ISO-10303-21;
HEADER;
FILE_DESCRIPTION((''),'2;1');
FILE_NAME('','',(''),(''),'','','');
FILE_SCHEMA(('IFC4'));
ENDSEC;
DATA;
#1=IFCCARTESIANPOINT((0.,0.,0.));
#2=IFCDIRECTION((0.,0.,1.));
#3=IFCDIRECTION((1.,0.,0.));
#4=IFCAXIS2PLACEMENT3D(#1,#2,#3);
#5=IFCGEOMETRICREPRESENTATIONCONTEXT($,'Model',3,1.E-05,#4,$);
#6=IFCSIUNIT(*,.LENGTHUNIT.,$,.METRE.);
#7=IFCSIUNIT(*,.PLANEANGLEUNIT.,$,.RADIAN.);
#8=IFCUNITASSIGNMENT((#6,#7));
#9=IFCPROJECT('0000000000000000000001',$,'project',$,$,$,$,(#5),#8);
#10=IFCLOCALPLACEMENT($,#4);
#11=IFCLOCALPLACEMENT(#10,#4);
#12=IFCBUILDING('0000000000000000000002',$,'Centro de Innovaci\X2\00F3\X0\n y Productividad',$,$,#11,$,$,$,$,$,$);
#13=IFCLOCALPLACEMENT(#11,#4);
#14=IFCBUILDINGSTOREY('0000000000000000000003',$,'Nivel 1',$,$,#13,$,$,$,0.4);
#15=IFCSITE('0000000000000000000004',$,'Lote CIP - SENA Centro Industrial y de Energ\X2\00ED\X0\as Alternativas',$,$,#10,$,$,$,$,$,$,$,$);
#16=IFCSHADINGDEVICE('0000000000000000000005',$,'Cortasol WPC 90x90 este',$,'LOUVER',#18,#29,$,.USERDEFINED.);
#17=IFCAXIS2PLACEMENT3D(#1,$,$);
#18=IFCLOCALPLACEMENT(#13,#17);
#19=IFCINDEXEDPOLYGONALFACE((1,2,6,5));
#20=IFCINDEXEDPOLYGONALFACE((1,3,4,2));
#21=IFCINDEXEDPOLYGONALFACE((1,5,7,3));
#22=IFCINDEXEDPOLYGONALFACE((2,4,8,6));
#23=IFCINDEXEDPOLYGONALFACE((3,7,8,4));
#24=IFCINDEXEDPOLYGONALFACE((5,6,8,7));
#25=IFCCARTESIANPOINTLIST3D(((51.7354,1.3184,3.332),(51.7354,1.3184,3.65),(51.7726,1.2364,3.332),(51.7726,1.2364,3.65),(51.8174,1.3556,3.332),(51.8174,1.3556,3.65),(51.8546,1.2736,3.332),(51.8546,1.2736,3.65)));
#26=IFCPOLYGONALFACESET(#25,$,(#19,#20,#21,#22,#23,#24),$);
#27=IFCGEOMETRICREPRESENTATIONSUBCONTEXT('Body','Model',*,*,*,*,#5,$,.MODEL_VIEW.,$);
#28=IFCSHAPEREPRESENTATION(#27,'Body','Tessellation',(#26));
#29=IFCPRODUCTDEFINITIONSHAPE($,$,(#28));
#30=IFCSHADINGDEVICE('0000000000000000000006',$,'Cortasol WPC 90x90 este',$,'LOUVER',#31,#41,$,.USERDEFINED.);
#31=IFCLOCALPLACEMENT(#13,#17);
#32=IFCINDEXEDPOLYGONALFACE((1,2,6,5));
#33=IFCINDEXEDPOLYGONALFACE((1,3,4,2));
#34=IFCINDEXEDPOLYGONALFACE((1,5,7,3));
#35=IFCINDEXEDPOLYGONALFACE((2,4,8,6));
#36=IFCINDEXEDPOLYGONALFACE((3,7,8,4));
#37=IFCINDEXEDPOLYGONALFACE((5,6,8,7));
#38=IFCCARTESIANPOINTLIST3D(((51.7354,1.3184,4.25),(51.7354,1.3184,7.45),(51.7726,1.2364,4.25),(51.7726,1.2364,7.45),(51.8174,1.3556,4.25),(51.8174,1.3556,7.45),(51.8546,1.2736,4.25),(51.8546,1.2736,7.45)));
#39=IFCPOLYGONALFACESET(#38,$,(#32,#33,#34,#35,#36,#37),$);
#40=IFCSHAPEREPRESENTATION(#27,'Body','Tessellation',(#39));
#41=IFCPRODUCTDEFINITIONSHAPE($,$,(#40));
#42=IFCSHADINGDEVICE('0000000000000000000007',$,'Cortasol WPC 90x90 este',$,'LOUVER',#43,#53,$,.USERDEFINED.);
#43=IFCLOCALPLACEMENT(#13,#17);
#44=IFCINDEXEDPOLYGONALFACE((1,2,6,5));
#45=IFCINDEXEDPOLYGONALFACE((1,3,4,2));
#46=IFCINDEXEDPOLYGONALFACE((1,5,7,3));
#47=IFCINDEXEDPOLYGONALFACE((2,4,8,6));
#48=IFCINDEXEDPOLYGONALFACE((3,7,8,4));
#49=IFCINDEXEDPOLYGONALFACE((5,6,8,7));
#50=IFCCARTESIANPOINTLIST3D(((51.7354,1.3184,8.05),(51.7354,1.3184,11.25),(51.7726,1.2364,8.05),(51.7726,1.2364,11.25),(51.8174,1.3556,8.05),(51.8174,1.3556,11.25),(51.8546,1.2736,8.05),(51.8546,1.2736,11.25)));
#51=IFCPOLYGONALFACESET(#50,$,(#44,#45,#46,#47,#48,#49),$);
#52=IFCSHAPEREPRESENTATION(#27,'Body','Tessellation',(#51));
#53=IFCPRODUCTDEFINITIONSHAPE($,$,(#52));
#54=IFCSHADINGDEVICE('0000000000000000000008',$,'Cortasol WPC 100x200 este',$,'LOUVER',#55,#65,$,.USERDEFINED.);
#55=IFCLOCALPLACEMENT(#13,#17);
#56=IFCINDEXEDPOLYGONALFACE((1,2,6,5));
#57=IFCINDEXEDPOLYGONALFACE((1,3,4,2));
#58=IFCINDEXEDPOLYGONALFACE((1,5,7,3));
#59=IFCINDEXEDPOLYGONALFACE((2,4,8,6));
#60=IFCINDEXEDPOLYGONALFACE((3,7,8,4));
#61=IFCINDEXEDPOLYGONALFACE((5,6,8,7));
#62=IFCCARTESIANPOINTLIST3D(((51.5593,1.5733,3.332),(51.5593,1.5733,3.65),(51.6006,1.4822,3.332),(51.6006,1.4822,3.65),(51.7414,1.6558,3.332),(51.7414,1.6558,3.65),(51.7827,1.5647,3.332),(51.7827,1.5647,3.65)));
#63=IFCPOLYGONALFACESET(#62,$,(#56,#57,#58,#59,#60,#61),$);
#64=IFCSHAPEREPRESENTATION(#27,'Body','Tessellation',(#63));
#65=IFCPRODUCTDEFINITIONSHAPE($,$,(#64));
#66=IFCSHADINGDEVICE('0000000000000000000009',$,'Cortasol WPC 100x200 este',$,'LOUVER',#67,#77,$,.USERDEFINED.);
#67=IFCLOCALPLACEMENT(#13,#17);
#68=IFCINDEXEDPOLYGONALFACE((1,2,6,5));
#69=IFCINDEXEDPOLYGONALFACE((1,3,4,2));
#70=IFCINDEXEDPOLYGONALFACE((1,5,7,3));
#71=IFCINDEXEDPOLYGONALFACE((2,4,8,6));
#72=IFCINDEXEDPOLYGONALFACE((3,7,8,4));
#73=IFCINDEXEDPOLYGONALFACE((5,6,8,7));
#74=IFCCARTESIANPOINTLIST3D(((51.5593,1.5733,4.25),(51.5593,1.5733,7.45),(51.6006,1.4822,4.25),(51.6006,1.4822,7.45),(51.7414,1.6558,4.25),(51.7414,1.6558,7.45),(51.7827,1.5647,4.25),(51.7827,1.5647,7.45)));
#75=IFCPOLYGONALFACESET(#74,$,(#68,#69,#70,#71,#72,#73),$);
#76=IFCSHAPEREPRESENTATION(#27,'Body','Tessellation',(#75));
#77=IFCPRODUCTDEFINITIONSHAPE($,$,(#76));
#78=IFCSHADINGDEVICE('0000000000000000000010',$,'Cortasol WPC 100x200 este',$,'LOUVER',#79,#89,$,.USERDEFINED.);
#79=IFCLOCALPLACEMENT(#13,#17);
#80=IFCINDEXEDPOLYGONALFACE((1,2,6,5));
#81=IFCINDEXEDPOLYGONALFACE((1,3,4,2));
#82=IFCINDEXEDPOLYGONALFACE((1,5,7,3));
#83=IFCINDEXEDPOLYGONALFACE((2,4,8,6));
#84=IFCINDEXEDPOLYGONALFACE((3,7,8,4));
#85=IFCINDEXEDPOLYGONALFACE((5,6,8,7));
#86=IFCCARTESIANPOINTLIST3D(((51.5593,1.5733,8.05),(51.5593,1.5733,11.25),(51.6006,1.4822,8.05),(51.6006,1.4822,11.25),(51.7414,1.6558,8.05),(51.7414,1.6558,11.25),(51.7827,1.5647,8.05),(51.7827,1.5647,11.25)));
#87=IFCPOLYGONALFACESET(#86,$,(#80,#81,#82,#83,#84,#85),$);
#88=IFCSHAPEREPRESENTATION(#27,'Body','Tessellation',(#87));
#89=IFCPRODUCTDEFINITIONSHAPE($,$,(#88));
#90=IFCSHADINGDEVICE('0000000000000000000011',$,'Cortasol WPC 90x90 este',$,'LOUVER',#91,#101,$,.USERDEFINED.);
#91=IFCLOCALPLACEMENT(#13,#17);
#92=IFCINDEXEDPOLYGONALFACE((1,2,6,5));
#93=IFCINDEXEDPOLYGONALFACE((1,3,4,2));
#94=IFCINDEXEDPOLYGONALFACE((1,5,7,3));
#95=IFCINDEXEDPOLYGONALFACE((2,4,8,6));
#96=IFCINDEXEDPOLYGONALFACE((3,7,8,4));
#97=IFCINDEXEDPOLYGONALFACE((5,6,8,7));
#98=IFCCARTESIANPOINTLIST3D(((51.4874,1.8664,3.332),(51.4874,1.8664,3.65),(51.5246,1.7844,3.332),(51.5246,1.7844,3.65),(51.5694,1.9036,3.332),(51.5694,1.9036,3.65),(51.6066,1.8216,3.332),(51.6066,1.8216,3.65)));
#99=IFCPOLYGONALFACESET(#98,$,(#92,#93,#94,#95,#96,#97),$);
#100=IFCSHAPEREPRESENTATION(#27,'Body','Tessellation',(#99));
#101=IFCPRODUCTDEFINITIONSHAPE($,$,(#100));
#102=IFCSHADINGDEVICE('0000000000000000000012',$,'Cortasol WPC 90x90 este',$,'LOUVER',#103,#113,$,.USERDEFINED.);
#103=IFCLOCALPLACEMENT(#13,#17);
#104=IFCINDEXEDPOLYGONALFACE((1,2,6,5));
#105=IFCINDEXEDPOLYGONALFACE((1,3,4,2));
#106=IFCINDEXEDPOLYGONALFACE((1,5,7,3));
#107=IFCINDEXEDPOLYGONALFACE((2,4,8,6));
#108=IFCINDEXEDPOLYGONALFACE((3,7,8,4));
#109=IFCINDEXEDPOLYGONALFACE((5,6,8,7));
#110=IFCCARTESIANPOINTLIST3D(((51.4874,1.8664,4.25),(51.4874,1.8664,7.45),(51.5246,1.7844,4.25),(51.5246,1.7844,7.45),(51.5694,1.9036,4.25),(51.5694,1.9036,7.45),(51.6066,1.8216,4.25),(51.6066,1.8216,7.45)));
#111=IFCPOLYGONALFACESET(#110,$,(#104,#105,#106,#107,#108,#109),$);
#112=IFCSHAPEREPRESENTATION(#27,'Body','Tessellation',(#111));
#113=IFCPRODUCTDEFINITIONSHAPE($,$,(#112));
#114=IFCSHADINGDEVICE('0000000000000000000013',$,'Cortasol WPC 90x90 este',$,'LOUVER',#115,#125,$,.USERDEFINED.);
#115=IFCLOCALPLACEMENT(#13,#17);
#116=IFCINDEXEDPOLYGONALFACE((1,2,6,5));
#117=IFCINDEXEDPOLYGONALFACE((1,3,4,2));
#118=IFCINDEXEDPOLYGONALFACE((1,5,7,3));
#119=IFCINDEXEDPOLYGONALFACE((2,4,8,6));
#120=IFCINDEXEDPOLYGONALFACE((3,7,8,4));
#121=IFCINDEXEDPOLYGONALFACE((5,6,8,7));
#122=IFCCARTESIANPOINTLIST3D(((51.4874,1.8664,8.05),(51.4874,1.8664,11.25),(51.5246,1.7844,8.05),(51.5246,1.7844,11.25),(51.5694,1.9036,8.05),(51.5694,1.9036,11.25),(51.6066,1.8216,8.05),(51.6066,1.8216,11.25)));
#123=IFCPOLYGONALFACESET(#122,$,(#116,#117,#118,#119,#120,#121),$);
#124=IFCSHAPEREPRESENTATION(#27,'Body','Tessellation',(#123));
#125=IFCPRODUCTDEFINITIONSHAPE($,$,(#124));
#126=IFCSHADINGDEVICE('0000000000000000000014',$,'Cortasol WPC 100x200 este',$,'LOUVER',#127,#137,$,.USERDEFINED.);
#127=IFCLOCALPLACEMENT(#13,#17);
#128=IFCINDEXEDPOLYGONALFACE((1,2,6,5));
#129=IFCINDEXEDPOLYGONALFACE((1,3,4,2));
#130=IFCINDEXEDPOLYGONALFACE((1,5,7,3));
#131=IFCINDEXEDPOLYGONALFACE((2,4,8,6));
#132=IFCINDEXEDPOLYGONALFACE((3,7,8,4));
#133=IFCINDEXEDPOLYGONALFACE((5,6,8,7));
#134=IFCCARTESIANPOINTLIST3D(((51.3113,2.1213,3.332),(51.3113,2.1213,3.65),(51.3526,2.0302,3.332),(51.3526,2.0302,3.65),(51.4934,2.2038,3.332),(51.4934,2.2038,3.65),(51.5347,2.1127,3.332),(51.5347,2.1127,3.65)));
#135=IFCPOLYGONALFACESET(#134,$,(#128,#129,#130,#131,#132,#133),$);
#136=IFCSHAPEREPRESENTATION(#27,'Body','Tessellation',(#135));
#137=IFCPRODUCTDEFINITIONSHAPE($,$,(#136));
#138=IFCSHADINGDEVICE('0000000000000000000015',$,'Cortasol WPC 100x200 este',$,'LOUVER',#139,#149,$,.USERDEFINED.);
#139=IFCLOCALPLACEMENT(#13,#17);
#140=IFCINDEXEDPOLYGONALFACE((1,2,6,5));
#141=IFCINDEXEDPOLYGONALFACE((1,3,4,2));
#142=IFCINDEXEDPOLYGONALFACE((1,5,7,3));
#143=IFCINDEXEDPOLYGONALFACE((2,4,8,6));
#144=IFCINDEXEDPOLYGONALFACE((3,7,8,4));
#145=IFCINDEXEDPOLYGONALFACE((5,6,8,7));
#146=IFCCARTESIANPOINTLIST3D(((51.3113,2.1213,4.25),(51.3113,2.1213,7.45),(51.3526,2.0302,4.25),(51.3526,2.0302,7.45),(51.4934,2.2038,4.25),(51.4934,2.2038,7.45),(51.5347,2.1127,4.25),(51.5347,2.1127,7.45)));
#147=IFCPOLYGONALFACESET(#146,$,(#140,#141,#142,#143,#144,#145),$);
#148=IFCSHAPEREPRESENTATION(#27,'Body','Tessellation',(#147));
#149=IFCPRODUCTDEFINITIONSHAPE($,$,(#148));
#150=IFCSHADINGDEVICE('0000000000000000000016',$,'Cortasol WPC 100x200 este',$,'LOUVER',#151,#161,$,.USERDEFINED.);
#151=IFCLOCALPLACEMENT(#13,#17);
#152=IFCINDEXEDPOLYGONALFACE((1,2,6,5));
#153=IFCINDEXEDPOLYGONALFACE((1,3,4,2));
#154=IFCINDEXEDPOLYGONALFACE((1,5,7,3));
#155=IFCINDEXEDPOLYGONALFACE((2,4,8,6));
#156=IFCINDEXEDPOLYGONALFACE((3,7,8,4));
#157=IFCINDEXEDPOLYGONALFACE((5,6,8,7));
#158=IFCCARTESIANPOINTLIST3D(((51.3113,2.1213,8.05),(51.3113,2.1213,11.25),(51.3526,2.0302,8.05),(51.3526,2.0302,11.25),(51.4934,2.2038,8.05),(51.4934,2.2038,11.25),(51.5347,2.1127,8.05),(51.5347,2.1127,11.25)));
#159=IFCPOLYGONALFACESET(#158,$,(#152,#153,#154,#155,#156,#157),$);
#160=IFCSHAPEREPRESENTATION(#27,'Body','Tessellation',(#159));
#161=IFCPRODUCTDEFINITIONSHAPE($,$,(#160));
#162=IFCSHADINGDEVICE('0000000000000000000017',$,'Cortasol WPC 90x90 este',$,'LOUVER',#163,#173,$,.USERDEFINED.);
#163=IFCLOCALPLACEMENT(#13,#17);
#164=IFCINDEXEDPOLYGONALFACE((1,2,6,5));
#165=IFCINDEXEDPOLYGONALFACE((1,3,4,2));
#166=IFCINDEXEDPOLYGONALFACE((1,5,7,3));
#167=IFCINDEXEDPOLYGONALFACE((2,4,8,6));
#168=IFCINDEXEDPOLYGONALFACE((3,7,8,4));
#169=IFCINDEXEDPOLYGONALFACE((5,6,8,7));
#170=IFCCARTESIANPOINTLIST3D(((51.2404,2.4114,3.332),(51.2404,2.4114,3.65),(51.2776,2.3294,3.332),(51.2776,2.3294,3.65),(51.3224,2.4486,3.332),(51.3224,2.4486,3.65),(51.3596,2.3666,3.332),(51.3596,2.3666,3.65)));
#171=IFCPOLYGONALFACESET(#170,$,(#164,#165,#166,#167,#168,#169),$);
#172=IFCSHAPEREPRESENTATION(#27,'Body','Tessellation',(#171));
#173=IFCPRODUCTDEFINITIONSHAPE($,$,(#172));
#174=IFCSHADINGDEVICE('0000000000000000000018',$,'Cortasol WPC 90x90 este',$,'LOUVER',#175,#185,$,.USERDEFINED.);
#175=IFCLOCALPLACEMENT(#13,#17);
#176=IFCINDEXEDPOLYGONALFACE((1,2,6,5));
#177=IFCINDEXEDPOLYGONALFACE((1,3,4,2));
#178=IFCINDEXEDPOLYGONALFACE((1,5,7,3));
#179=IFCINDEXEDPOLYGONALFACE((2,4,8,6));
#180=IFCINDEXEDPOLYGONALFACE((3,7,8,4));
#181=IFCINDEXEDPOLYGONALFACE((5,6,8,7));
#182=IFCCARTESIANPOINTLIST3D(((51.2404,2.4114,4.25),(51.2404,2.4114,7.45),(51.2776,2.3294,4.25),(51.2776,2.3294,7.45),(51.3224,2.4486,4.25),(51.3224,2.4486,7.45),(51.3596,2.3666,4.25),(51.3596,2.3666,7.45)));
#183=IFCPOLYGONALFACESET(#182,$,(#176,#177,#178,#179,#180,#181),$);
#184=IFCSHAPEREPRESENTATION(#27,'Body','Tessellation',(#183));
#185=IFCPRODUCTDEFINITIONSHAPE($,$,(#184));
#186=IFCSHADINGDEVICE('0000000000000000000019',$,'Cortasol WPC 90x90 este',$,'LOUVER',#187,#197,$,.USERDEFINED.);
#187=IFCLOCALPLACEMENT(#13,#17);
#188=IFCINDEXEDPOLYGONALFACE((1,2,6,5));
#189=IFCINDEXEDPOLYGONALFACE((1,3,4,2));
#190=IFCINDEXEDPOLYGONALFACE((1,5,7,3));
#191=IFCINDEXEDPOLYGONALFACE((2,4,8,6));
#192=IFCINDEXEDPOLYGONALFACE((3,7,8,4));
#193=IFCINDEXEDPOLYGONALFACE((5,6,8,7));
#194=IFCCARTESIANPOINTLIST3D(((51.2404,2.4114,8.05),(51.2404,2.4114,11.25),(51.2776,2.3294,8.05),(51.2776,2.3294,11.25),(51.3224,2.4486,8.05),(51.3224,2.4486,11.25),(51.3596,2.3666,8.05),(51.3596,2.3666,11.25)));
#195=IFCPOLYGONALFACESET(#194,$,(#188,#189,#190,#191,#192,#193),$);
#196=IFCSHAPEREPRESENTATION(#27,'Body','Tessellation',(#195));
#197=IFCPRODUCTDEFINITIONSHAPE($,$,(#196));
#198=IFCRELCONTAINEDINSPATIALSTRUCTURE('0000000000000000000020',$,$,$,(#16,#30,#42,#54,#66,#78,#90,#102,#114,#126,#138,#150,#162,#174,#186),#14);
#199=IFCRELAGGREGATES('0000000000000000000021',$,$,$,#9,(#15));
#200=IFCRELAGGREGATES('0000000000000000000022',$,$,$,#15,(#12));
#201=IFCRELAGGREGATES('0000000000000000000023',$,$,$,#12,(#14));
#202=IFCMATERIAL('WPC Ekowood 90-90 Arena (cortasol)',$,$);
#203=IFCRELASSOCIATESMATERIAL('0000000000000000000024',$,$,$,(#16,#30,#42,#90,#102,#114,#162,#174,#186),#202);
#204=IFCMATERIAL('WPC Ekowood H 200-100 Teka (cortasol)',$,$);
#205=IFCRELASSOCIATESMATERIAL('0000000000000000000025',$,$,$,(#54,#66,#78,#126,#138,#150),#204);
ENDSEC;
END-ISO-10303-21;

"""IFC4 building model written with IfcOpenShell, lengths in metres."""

from ifc_helpers import new_model, si_unit, frame, origin_with_axes, place, context, subcontext, project, spatial, polyline, outline, extrude, material, element, save


model = new_model("IFC4")

# Units and contexts
model_context = context("Model", 3, precision=1e-05, world=origin_with_axes())
body_context = subcontext(model_context, "Body", "Model", "MODEL_VIEW")
ifc_project = project(units=[si_unit("LENGTHUNIT", "METRE"), si_unit("PLANEANGLEUNIT", "RADIAN")], contexts=[model_context])

# Site, building, storey
site_placement = place(None, origin_with_axes())
site = spatial("IfcSite", under=ifc_project, at=site_placement, Name="Lote CIP - SENA Centro Industrial y de Energías Alternativas")
building_placement = place(site_placement, origin_with_axes())
building = spatial("IfcBuilding", under=site, at=building_placement, Name="Centro de Innovación y Productividad")
storey_placement = place(building_placement, origin_with_axes())
storey = spatial("IfcBuildingStorey", under=building, at=storey_placement, Name="Nivel 1", Elevation=0.4)

# Shading devices
ifc_material_1 = material(Name="WPC Ekowood 90-90 Arena (cortasol)")
shading_device_1_placement = place(storey_placement, origin_with_axes())
element("IfcShadingDevice", 1, at=shading_device_1_placement, inside=storey, material=ifc_material_1, Name="Cortasol WPC 90x90 este", ObjectType="LOUVER", PredefinedType="USERDEFINED", context=body_context, shape_type="SweptSolid", body=[
    extrude(outline(polyline([(51.7354, 1.3184), (51.8174, 1.3556), (51.8546, 1.2736), (51.7726, 1.2364), (51.7354, 1.3184)])), frame((0.0, 0.0, 3.332)), (0.0, 0.0, 1.0), 0.318),
])
shading_device_2_placement = place(storey_placement, origin_with_axes())
element("IfcShadingDevice", 2, at=shading_device_2_placement, inside=storey, material=ifc_material_1, Name="Cortasol WPC 90x90 este", ObjectType="LOUVER", PredefinedType="USERDEFINED", context=body_context, shape_type="SweptSolid", body=[
    extrude(outline(polyline([(51.7354, 1.3184), (51.8174, 1.3556), (51.8546, 1.2736), (51.7726, 1.2364), (51.7354, 1.3184)])), frame((0.0, 0.0, 4.25)), (0.0, 0.0, 1.0), 3.2),
])
shading_device_3_placement = place(storey_placement, origin_with_axes())
element("IfcShadingDevice", 3, at=shading_device_3_placement, inside=storey, material=ifc_material_1, Name="Cortasol WPC 90x90 este", ObjectType="LOUVER", PredefinedType="USERDEFINED", context=body_context, shape_type="SweptSolid", body=[
    extrude(outline(polyline([(51.7354, 1.3184), (51.8174, 1.3556), (51.8546, 1.2736), (51.7726, 1.2364), (51.7354, 1.3184)])), frame((0.0, 0.0, 8.05)), (0.0, 0.0, 1.0), 3.2),
])
ifc_material_2 = material(Name="WPC Ekowood H 200-100 Teka (cortasol)")
shading_device_4_placement = place(storey_placement, origin_with_axes())
element("IfcShadingDevice", 4, at=shading_device_4_placement, inside=storey, material=ifc_material_2, Name="Cortasol WPC 100x200 este", ObjectType="LOUVER", PredefinedType="USERDEFINED", context=body_context, shape_type="SweptSolid", body=[
    extrude(outline(polyline([(51.5593, 1.5733), (51.7414, 1.6558), (51.7827, 1.5647), (51.6006, 1.4822), (51.5593, 1.5733)])), frame((0.0, 0.0, 3.332)), (0.0, 0.0, 1.0), 0.318),
])
shading_device_5_placement = place(storey_placement, origin_with_axes())
element("IfcShadingDevice", 5, at=shading_device_5_placement, inside=storey, material=ifc_material_2, Name="Cortasol WPC 100x200 este", ObjectType="LOUVER", PredefinedType="USERDEFINED", context=body_context, shape_type="SweptSolid", body=[
    extrude(outline(polyline([(51.5593, 1.5733), (51.7414, 1.6558), (51.7827, 1.5647), (51.6006, 1.4822), (51.5593, 1.5733)])), frame((0.0, 0.0, 4.25)), (0.0, 0.0, 1.0), 3.2),
])
shading_device_6_placement = place(storey_placement, origin_with_axes())
element("IfcShadingDevice", 6, at=shading_device_6_placement, inside=storey, material=ifc_material_2, Name="Cortasol WPC 100x200 este", ObjectType="LOUVER", PredefinedType="USERDEFINED", context=body_context, shape_type="SweptSolid", body=[
    extrude(outline(polyline([(51.5593, 1.5733), (51.7414, 1.6558), (51.7827, 1.5647), (51.6006, 1.4822), (51.5593, 1.5733)])), frame((0.0, 0.0, 8.05)), (0.0, 0.0, 1.0), 3.2),
])
shading_device_7_placement = place(storey_placement, origin_with_axes())
element("IfcShadingDevice", 7, at=shading_device_7_placement, inside=storey, material=ifc_material_1, Name="Cortasol WPC 90x90 este", ObjectType="LOUVER", PredefinedType="USERDEFINED", context=body_context, shape_type="SweptSolid", body=[
    extrude(outline(polyline([(51.4874, 1.8664), (51.5694, 1.9036), (51.6066, 1.8216), (51.5246, 1.7844), (51.4874, 1.8664)])), frame((0.0, 0.0, 3.332)), (0.0, 0.0, 1.0), 0.318),
])
shading_device_8_placement = place(storey_placement, origin_with_axes())
element("IfcShadingDevice", 8, at=shading_device_8_placement, inside=storey, material=ifc_material_1, Name="Cortasol WPC 90x90 este", ObjectType="LOUVER", PredefinedType="USERDEFINED", context=body_context, shape_type="SweptSolid", body=[
    extrude(outline(polyline([(51.4874, 1.8664), (51.5694, 1.9036), (51.6066, 1.8216), (51.5246, 1.7844), (51.4874, 1.8664)])), frame((0.0, 0.0, 4.25)), (0.0, 0.0, 1.0), 3.2),
])
shading_device_9_placement = place(storey_placement, origin_with_axes())
element("IfcShadingDevice", 9, at=shading_device_9_placement, inside=storey, material=ifc_material_1, Name="Cortasol WPC 90x90 este", ObjectType="LOUVER", PredefinedType="USERDEFINED", context=body_context, shape_type="SweptSolid", body=[
    extrude(outline(polyline([(51.4874, 1.8664), (51.5694, 1.9036), (51.6066, 1.8216), (51.5246, 1.7844), (51.4874, 1.8664)])), frame((0.0, 0.0, 8.05)), (0.0, 0.0, 1.0), 3.2),
])
shading_device_10_placement = place(storey_placement, origin_with_axes())
element("IfcShadingDevice", 10, at=shading_device_10_placement, inside=storey, material=ifc_material_2, Name="Cortasol WPC 100x200 este", ObjectType="LOUVER", PredefinedType="USERDEFINED", context=body_context, shape_type="SweptSolid", body=[
    extrude(outline(polyline([(51.3113, 2.1213), (51.4934, 2.2038), (51.5347, 2.1127), (51.3526, 2.0302), (51.3113, 2.1213)])), frame((0.0, 0.0, 3.332)), (0.0, 0.0, 1.0), 0.318),
])
shading_device_11_placement = place(storey_placement, origin_with_axes())
element("IfcShadingDevice", 11, at=shading_device_11_placement, inside=storey, material=ifc_material_2, Name="Cortasol WPC 100x200 este", ObjectType="LOUVER", PredefinedType="USERDEFINED", context=body_context, shape_type="SweptSolid", body=[
    extrude(outline(polyline([(51.3113, 2.1213), (51.4934, 2.2038), (51.5347, 2.1127), (51.3526, 2.0302), (51.3113, 2.1213)])), frame((0.0, 0.0, 4.25)), (0.0, 0.0, 1.0), 3.2),
])
shading_device_12_placement = place(storey_placement, origin_with_axes())
element("IfcShadingDevice", 12, at=shading_device_12_placement, inside=storey, material=ifc_material_2, Name="Cortasol WPC 100x200 este", ObjectType="LOUVER", PredefinedType="USERDEFINED", context=body_context, shape_type="SweptSolid", body=[
    extrude(outline(polyline([(51.3113, 2.1213), (51.4934, 2.2038), (51.5347, 2.1127), (51.3526, 2.0302), (51.3113, 2.1213)])), frame((0.0, 0.0, 8.05)), (0.0, 0.0, 1.0), 3.2),
])
shading_device_13_placement = place(storey_placement, origin_with_axes())
element("IfcShadingDevice", 13, at=shading_device_13_placement, inside=storey, material=ifc_material_1, Name="Cortasol WPC 90x90 este", ObjectType="LOUVER", PredefinedType="USERDEFINED", context=body_context, shape_type="SweptSolid", body=[
    extrude(outline(polyline([(51.2404, 2.4114), (51.3224, 2.4486), (51.3596, 2.3666), (51.2776, 2.3294), (51.2404, 2.4114)])), frame((0.0, 0.0, 3.332)), (0.0, 0.0, 1.0), 0.318),
])
shading_device_14_placement = place(storey_placement, origin_with_axes())
element("IfcShadingDevice", 14, at=shading_device_14_placement, inside=storey, material=ifc_material_1, Name="Cortasol WPC 90x90 este", ObjectType="LOUVER", PredefinedType="USERDEFINED", context=body_context, shape_type="SweptSolid", body=[
    extrude(outline(polyline([(51.2404, 2.4114), (51.3224, 2.4486), (51.3596, 2.3666), (51.2776, 2.3294), (51.2404, 2.4114)])), frame((0.0, 0.0, 4.25)), (0.0, 0.0, 1.0), 3.2),
])
shading_device_15_placement = place(storey_placement, origin_with_axes())
element("IfcShadingDevice", 15, at=shading_device_15_placement, inside=storey, material=ifc_material_1, Name="Cortasol WPC 90x90 este", ObjectType="LOUVER", PredefinedType="USERDEFINED", context=body_context, shape_type="SweptSolid", body=[
    extrude(outline(polyline([(51.2404, 2.4114), (51.3224, 2.4486), (51.3596, 2.3666), (51.2776, 2.3294), (51.2404, 2.4114)])), frame((0.0, 0.0, 8.05)), (0.0, 0.0, 1.0), 3.2),
])

save(model, "model.ifc")
